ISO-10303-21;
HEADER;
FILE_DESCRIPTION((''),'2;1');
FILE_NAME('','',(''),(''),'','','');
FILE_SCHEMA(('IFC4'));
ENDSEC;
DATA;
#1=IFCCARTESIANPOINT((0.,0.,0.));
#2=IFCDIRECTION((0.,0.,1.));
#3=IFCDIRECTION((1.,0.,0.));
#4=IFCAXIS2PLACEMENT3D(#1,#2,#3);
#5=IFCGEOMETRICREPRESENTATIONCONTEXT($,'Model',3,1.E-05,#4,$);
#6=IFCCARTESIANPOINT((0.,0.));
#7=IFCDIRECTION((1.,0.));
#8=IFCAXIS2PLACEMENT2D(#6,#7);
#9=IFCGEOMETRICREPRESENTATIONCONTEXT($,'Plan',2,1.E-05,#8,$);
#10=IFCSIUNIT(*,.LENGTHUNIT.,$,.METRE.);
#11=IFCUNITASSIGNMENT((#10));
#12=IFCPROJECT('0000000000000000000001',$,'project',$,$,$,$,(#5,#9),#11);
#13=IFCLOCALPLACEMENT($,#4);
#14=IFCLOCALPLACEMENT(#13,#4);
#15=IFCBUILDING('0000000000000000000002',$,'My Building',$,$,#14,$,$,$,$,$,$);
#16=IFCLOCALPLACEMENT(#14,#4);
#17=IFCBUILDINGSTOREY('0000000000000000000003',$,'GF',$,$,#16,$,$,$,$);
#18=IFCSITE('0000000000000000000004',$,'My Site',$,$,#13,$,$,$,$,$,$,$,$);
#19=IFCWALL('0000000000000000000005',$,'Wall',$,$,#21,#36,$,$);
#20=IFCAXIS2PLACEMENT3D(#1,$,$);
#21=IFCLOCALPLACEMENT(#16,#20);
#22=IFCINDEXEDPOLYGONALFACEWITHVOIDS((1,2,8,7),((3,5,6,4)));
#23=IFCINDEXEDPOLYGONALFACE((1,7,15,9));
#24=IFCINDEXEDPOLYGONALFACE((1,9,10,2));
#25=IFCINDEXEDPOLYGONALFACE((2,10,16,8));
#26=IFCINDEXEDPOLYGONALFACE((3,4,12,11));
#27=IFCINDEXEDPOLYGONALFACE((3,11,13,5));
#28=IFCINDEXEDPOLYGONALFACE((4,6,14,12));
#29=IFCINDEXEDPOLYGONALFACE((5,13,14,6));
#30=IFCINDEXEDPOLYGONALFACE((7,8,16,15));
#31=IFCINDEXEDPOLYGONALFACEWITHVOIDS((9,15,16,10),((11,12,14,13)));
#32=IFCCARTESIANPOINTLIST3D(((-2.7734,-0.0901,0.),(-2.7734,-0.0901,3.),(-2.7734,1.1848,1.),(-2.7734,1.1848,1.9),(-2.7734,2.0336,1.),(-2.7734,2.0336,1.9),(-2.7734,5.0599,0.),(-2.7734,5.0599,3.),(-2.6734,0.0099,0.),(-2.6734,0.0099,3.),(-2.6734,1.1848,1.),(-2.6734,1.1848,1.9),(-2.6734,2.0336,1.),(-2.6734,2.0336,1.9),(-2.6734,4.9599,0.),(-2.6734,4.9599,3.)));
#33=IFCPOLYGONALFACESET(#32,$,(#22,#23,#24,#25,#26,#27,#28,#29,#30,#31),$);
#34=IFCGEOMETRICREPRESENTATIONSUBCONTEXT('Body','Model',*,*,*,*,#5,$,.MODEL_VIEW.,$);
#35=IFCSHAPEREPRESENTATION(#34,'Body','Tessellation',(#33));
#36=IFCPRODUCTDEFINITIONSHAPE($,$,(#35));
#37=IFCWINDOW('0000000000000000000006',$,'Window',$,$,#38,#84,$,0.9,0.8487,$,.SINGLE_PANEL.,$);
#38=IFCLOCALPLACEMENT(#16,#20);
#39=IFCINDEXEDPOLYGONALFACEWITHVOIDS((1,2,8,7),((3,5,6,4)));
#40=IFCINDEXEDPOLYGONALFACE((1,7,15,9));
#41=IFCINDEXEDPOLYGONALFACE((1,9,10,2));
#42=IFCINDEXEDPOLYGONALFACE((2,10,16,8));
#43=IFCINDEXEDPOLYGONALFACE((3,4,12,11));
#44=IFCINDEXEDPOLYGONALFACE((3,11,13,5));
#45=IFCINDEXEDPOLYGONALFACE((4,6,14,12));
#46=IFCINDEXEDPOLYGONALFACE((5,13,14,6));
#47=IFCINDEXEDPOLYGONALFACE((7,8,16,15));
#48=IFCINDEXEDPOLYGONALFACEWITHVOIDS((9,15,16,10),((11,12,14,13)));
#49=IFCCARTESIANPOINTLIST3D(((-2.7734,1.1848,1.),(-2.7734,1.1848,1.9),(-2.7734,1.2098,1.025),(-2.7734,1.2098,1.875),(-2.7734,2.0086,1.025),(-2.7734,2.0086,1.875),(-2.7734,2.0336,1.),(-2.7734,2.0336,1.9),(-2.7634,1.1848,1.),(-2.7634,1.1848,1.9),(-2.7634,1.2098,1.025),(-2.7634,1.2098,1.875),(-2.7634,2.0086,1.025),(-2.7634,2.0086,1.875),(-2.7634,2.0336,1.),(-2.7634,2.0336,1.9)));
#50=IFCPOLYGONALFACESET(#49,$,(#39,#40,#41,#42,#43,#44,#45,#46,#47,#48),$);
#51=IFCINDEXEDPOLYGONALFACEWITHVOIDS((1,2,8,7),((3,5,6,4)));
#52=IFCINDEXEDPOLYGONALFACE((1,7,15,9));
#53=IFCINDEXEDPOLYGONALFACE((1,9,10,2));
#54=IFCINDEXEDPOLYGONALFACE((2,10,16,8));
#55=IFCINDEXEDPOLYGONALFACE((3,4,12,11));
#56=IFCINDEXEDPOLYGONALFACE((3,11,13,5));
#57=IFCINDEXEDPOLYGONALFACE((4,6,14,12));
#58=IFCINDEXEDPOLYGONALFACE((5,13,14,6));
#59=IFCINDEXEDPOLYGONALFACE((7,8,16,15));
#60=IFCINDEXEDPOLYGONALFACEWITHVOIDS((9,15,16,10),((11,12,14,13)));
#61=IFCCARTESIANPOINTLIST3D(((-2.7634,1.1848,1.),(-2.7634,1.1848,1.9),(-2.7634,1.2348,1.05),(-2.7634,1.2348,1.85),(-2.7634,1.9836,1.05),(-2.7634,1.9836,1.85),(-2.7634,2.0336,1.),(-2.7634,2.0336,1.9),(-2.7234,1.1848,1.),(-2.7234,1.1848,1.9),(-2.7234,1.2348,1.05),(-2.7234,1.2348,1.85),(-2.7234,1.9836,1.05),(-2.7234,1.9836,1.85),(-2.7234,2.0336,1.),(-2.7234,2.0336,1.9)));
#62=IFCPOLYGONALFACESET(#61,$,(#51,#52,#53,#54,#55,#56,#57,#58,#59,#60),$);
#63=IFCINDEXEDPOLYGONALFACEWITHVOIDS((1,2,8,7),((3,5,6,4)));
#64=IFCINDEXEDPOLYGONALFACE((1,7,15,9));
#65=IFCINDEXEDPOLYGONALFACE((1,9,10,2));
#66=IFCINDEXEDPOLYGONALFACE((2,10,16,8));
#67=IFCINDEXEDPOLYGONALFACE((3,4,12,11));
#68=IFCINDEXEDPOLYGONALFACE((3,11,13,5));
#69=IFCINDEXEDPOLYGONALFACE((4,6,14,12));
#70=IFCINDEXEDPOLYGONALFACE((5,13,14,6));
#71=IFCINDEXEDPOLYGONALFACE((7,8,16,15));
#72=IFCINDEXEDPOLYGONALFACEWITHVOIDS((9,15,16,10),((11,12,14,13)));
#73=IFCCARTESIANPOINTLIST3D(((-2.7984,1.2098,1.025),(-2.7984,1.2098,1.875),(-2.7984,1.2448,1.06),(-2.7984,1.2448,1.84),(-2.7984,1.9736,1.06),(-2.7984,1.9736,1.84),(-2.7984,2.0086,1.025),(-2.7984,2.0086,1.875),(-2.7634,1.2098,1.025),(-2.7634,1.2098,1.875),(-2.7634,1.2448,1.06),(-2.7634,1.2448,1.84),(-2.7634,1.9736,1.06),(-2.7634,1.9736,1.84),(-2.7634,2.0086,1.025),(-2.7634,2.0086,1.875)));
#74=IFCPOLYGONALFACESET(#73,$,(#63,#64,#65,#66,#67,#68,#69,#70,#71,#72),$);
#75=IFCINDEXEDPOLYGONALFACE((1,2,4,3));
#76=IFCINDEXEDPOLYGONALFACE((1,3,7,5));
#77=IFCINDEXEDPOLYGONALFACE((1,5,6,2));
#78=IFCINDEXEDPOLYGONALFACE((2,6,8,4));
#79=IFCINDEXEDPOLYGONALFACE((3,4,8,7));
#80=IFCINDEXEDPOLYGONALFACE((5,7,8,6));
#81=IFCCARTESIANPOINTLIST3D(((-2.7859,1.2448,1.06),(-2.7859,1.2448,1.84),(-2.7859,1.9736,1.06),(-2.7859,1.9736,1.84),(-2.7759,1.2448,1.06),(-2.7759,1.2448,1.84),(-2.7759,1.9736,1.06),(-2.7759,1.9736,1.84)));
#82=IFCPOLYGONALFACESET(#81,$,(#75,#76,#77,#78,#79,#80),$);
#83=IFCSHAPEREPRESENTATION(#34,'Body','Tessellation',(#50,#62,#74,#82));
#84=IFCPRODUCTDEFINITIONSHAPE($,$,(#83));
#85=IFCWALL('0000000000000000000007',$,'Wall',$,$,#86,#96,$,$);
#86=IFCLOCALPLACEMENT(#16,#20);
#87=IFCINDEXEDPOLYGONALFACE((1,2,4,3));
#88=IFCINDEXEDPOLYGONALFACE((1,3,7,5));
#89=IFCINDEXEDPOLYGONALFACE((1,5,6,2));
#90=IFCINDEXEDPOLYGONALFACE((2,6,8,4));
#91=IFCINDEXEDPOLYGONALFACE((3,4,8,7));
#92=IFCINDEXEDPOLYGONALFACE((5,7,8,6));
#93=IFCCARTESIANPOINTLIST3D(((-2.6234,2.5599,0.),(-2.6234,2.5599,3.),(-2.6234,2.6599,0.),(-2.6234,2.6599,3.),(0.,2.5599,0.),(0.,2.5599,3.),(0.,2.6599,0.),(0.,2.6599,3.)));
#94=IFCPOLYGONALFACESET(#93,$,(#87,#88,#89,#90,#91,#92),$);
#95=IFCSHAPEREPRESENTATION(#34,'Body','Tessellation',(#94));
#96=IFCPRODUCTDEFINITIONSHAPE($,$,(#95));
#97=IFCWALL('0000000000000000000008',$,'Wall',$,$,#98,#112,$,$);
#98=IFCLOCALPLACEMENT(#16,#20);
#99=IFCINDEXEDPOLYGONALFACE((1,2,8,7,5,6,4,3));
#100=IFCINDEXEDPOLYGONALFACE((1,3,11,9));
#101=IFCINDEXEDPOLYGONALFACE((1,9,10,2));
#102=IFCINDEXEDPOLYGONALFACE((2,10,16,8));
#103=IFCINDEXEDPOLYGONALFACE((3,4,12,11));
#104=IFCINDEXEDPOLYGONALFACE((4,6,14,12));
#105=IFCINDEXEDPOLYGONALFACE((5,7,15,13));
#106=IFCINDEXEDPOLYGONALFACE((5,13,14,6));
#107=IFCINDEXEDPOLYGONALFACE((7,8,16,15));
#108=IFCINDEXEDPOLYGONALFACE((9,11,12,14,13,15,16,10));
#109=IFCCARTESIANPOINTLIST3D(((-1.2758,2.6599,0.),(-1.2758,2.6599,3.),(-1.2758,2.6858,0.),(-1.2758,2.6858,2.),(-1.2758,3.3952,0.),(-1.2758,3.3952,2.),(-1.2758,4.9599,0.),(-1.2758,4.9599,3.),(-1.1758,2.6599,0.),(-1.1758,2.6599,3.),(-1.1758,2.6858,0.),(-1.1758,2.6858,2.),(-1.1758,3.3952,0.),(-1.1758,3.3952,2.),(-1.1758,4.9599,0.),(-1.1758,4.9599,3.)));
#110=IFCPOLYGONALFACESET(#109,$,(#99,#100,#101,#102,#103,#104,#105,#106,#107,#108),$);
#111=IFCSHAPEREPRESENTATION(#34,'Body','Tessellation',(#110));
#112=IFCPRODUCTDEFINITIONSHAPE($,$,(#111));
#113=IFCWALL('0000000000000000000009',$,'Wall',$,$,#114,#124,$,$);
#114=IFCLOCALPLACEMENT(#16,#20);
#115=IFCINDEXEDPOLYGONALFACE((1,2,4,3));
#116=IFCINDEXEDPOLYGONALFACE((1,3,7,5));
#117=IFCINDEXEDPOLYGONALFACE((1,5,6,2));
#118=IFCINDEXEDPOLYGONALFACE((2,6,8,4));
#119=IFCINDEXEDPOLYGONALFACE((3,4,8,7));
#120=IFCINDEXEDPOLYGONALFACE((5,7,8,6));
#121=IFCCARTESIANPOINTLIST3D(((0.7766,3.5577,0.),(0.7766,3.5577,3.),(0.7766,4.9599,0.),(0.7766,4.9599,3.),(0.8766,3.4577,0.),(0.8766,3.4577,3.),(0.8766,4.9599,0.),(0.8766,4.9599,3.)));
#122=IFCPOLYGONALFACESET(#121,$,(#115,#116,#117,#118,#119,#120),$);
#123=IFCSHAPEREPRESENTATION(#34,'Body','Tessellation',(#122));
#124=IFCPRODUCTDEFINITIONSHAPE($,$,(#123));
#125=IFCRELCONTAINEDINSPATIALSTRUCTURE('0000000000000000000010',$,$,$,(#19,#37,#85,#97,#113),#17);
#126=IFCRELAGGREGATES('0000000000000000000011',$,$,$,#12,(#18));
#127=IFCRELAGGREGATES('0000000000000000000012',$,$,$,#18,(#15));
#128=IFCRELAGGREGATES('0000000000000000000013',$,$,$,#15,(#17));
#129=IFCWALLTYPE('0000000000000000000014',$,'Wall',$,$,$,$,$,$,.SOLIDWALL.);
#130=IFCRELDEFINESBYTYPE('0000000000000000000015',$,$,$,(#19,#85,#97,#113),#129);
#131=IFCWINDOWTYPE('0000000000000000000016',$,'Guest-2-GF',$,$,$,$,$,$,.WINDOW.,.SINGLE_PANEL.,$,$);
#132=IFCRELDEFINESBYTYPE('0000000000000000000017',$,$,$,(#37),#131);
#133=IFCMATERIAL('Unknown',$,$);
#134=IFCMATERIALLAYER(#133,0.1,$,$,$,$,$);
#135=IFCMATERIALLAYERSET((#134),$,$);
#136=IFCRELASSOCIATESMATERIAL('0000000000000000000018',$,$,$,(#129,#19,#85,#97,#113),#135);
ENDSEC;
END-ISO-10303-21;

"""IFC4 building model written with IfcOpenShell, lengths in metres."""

from ifc_helpers import new_model, entity, si_unit, frame, origin_with_axes, origin_2d_with_axis, place, context, subcontext, project, spatial, line, indexed_curve, outline, extrude, shape, source, transform, mapped, material, layer, layer_set, layer_usage, type_object, type_shapes, element, fill, save


model = new_model("IFC4")

# Units and contexts
model_context = context("Model", 3, precision=1e-05, world=origin_with_axes())
plan_context = context("Plan", 2, precision=1e-05, world=origin_2d_with_axis())
body_context_1 = subcontext(model_context, "Body", "Model", "MODEL_VIEW")
body_context_2 = subcontext(plan_context, "Body", "Plan", "PLAN_VIEW")
ifc_project = project(units=[si_unit("LENGTHUNIT", "METRE")], contexts=[model_context, plan_context])

# Site, building, storey
site_placement = place(None, origin_with_axes())
site = spatial("IfcSite", under=ifc_project, at=site_placement, Name="My Site")
building_placement = place(site_placement, origin_with_axes())
building = spatial("IfcBuilding", under=site, at=building_placement, Name="My Building")
storey_placement = place(building_placement, origin_with_axes())
storey = spatial("IfcBuildingStorey", under=building, at=storey_placement, Name="GF")

# Shared definitions
ifc_material = material(Name="Unknown")
ifc_layer = layer(ifc_material, 0.1)
ifc_layer_set = layer_set([ifc_layer])
wall_type = type_object("IfcWallType", Name="Wall", PredefinedType="SOLIDWALL", material=ifc_layer_set)

# Wall, opening, window
ifc_layer_usage_1 = layer_usage(ifc_layer_set, "AXIS2", "POSITIVE", 0.0)
wall_1_placement = place(storey_placement, frame((-2.7734, 5.0599, 0.0), z_axis=(0.0, 0.0, 1.0), x_axis=(0.0, -1.0, 0.0)))
wall_1 = element("IfcWall", 1, at=wall_1_placement, inside=storey, type_object=wall_type, material=ifc_layer_usage_1, Name="Wall", context=body_context_1, shape_type="SweptSolid", body=[
    extrude(outline(indexed_curve([(0.0, 0.0), (0.1, 0.1), (5.05, 0.1), (5.15, 0.0)], segments=[line(1, 2, 3, 4, 1)])), origin_with_axes(), (0.0, 0.0, 1.0), 3.0),
])
shared_shape_1 = source(origin_with_axes(), body_context_1, "Body", "SweptSolid", [
    extrude(outline(indexed_curve([(0.0, 0.0), (0.8487, 0.0), (0.8487, 0.9), (0.0, 0.9)], segments=[line(1, 2, 3, 4, 1)])), frame((0.0, -0.6, 0.0), z_axis=(0.0, -1.0, 0.0), x_axis=(1.0, 0.0, 0.0)), (0.0, 0.0, -1.0), 1.2),
])
opening_1_placement = place(wall_1_placement, frame((3.875, 0.1, 1.0), z_axis=(0.0, 0.0, 1.0), x_axis=(-1.0, 0.0, 0.0)))
opening_1 = element("IfcOpeningElement", 2, at=opening_1_placement, cuts=wall_1, PredefinedType="OPENING", context=body_context_1, shape_type="MappedRepresentation", body=[
    mapped(shared_shape_1, transform((0.0, 0.0, 0.0), x_axis=(1.0, 0.0, 0.0), y_axis=(0.0, 1.0, 0.0), z_axis=(0.0, 0.0, 1.0), scale=1.0)),
])
window_type_1 = type_object("IfcWindowType", Name="Guest-2-GF", PartitioningType="SINGLE_PANEL", PredefinedType="WINDOW")
shared_shape_2 = source(origin_with_axes(), body_context_1, "Body", "SweptSolid", [
    extrude(outline(indexed_curve([(0.0, 0.0), (0.8487, 0.0), (0.8487, 0.9), (0.0, 0.9)], segments=[line(1, 2, 3, 4, 1)]), holes=[indexed_curve([(0.025, 0.025), (0.8237, 0.025), (0.8237, 0.875), (0.025, 0.875)], segments=[line(1, 2, 3, 4, 1)])]), frame((0.0, 0.09, 0.0), z_axis=(0.0, -1.0, 0.0), x_axis=(1.0, 0.0, 0.0)), (0.0, 0.0, -1.0), 0.01),
    extrude(outline(indexed_curve([(0.0, 0.0), (0.8487, 0.0), (0.8487, 0.9), (0.0, 0.9)], segments=[line(1, 2, 3, 4, 1)]), holes=[indexed_curve([(0.05, 0.05), (0.7987, 0.05), (0.7987, 0.85), (0.05, 0.85)], segments=[line(1, 2, 3, 4, 1)])]), frame((0.0, 0.05, 0.0), z_axis=(0.0, -1.0, 0.0), x_axis=(1.0, 0.0, 0.0)), (0.0, 0.0, -1.0), 0.04),
    extrude(outline(indexed_curve([(0.0, 0.0), (0.7987, 0.0), (0.7987, 0.85), (0.0, 0.85)], segments=[line(1, 2, 3, 4, 1)]), holes=[indexed_curve([(0.035, 0.035), (0.7637, 0.035), (0.7637, 0.815), (0.035, 0.815)], segments=[line(1, 2, 3, 4, 1)])]), frame((0.025, 0.09, 0.025), z_axis=(0.0, -1.0, 0.0), x_axis=(1.0, 0.0, 0.0)), (0.0, 0.0, -1.0), 0.035),
    extrude(outline(indexed_curve([(0.035, 0.035), (0.7637, 0.035), (0.7637, 0.815), (0.035, 0.815)], segments=[line(1, 2, 3, 4, 1)])), frame((0.025, 0.1025, 0.025), z_axis=(0.0, -1.0, 0.0), x_axis=(1.0, 0.0, 0.0)), (0.0, 0.0, -1.0), 0.01),
])
shared_shape_3 = source(origin_with_axes(), body_context_2, "Body", "Curve2D", [
    entity("IfcIndexedPolyCurve", entity("IfcCartesianPointList2D", [[0.05, 0.05], [0.7987, 0.05]])),
    entity("IfcIndexedPolyCurve", entity("IfcCartesianPointList2D", [[0.0, 0.1], [0.025, 0.1], [0.025, 0.09], [0.05, 0.09], [0.05, 0.05], [0.0, 0.05]]), [entity("IfcLineIndex", [1, 2, 3, 4, 5, 6, 1])]),
    entity("IfcIndexedPolyCurve", entity("IfcCartesianPointList2D", [[0.8487, 0.1], [0.8237, 0.1], [0.8237, 0.09], [0.7987, 0.09], [0.7987, 0.05], [0.8487, 0.05]]), [entity("IfcLineIndex", [1, 2, 3, 4, 5, 6, 1])]),
    entity("IfcIndexedPolyCurve", entity("IfcCartesianPointList2D", [[0.025, 0.09], [0.06, 0.09], [0.06, 0.125], [0.025, 0.125]]), [entity("IfcLineIndex", [1, 2, 3, 4, 1])]),
    entity("IfcIndexedPolyCurve", entity("IfcCartesianPointList2D", [[0.8237, 0.09], [0.7887, 0.09], [0.7887, 0.125], [0.8237, 0.125]]), [entity("IfcLineIndex", [1, 2, 3, 4, 1])]),
    entity("IfcIndexedPolyCurve", entity("IfcCartesianPointList2D", [[0.06, 0.09], [0.7887, 0.09]])),
    entity("IfcIndexedPolyCurve", entity("IfcCartesianPointList2D", [[0.06, 0.125], [0.7887, 0.125]])),
    entity("IfcIndexedPolyCurve", entity("IfcCartesianPointList2D", [[0.06, 0.1075], [0.7887, 0.1075]])),
])
type_shapes(window_type_1, [shared_shape_2, shared_shape_3])
window_1_placement = place(opening_1_placement, frame((0.0, 0.0, 0.0), z_axis=(0.0, 0.0, 1.0), x_axis=(1.0, 0.0, 0.0)))
window_1 = element("IfcWindow", 3, at=window_1_placement, inside=storey, type_object=window_type_1, Name="Window", OverallHeight=0.9, OverallWidth=0.8487, PartitioningType="SINGLE_PANEL", shapes=[
    shape(body_context_1, "Body", "MappedRepresentation", [mapped(shared_shape_2, transform((0.0, 0.0, 0.0), x_axis=(1.0, 0.0, 0.0), y_axis=(0.0, 1.0, 0.0), z_axis=(0.0, 0.0, 1.0), scale=1.0))]),
    shape(body_context_2, "Body", "MappedRepresentation", [mapped(shared_shape_3, transform((0.0, 0.0, 0.0), x_axis=(1.0, 0.0, 0.0), y_axis=(0.0, 1.0, 0.0), z_axis=(0.0, 0.0, 1.0), scale=1.0))]),
])
fill(opening_1, window_1)

# Wall
ifc_layer_usage_2 = layer_usage(ifc_layer_set, "AXIS2", "POSITIVE", 0.0)
wall_2_placement = place(storey_placement, frame((0.0, 2.6599, 0.0), z_axis=(0.0, 0.0, 1.0), x_axis=(-1.0, 0.0, 0.0)))
element("IfcWall", 4, at=wall_2_placement, inside=storey, type_object=wall_type, material=ifc_layer_usage_2, Name="Wall", context=body_context_1, shape_type="SweptSolid", body=[
    extrude(outline(indexed_curve([(0.0, 0.0), (0.0, 0.1), (2.6234, 0.1), (2.6234, 0.0)], segments=[line(1, 2, 3, 4, 1)])), origin_with_axes(), (0.0, 0.0, 1.0), 3.0),
])

# Wall, opening
ifc_layer_usage_3 = layer_usage(ifc_layer_set, "AXIS2", "POSITIVE", 0.0)
wall_3_placement = place(storey_placement, frame((-1.1758, 2.6599, 0.0), z_axis=(0.0, 0.0, 1.0), x_axis=(0.0, 1.0, 0.0)))
wall_3 = element("IfcWall", 5, at=wall_3_placement, inside=storey, type_object=wall_type, material=ifc_layer_usage_3, Name="Wall", context=body_context_1, shape_type="SweptSolid", body=[
    extrude(outline(indexed_curve([(0.0, 0.0), (0.0, 0.1), (2.3, 0.1), (2.3, 0.0)], segments=[line(1, 2, 3, 4, 1)])), origin_with_axes(), (0.0, 0.0, 1.0), 3.0),
])
shared_shape_4 = source(origin_with_axes(), body_context_1, "Body", "SweptSolid", [
    extrude(outline(indexed_curve([(0.0, 0.0), (0.7094, 0.0), (0.7094, 2.0), (0.0, 2.0)], segments=[line(1, 2, 3, 4, 1)])), frame((0.0, -0.6, 0.0), z_axis=(0.0, -1.0, 0.0), x_axis=(1.0, 0.0, 0.0)), (0.0, 0.0, -1.0), 1.2),
])
opening_2_placement = place(wall_3_placement, frame((0.0259, 0.015, 0.0), z_axis=(0.0, 0.0, 1.0), x_axis=(1.0, 0.0, 0.0)))
element("IfcOpeningElement", 6, at=opening_2_placement, cuts=wall_3, PredefinedType="OPENING", context=body_context_1, shape_type="MappedRepresentation", body=[
    mapped(shared_shape_4, transform((0.0, 0.0, 0.0), x_axis=(1.0, 0.0, 0.0), y_axis=(0.0, 1.0, 0.0), z_axis=(0.0, 0.0, 1.0), scale=1.0)),
])

# Wall
ifc_layer_usage_4 = layer_usage(ifc_layer_set, "AXIS2", "POSITIVE", 0.0)
wall_4_placement = place(storey_placement, frame((0.7766, 4.9599, 0.0), z_axis=(0.0, 0.0, 1.0), x_axis=(0.0, -1.0, 0.0)))
element("IfcWall", 7, at=wall_4_placement, inside=storey, type_object=wall_type, material=ifc_layer_usage_4, Name="Wall", context=body_context_1, shape_type="SweptSolid", body=[
    extrude(outline(indexed_curve([(0.0, 0.0), (0.0, 0.1), (1.5022, 0.1), (1.4022, 0.0)], segments=[line(1, 2, 3, 4, 1)])), origin_with_axes(), (0.0, 0.0, 1.0), 3.0),
])

save(model, "model.ifc")
